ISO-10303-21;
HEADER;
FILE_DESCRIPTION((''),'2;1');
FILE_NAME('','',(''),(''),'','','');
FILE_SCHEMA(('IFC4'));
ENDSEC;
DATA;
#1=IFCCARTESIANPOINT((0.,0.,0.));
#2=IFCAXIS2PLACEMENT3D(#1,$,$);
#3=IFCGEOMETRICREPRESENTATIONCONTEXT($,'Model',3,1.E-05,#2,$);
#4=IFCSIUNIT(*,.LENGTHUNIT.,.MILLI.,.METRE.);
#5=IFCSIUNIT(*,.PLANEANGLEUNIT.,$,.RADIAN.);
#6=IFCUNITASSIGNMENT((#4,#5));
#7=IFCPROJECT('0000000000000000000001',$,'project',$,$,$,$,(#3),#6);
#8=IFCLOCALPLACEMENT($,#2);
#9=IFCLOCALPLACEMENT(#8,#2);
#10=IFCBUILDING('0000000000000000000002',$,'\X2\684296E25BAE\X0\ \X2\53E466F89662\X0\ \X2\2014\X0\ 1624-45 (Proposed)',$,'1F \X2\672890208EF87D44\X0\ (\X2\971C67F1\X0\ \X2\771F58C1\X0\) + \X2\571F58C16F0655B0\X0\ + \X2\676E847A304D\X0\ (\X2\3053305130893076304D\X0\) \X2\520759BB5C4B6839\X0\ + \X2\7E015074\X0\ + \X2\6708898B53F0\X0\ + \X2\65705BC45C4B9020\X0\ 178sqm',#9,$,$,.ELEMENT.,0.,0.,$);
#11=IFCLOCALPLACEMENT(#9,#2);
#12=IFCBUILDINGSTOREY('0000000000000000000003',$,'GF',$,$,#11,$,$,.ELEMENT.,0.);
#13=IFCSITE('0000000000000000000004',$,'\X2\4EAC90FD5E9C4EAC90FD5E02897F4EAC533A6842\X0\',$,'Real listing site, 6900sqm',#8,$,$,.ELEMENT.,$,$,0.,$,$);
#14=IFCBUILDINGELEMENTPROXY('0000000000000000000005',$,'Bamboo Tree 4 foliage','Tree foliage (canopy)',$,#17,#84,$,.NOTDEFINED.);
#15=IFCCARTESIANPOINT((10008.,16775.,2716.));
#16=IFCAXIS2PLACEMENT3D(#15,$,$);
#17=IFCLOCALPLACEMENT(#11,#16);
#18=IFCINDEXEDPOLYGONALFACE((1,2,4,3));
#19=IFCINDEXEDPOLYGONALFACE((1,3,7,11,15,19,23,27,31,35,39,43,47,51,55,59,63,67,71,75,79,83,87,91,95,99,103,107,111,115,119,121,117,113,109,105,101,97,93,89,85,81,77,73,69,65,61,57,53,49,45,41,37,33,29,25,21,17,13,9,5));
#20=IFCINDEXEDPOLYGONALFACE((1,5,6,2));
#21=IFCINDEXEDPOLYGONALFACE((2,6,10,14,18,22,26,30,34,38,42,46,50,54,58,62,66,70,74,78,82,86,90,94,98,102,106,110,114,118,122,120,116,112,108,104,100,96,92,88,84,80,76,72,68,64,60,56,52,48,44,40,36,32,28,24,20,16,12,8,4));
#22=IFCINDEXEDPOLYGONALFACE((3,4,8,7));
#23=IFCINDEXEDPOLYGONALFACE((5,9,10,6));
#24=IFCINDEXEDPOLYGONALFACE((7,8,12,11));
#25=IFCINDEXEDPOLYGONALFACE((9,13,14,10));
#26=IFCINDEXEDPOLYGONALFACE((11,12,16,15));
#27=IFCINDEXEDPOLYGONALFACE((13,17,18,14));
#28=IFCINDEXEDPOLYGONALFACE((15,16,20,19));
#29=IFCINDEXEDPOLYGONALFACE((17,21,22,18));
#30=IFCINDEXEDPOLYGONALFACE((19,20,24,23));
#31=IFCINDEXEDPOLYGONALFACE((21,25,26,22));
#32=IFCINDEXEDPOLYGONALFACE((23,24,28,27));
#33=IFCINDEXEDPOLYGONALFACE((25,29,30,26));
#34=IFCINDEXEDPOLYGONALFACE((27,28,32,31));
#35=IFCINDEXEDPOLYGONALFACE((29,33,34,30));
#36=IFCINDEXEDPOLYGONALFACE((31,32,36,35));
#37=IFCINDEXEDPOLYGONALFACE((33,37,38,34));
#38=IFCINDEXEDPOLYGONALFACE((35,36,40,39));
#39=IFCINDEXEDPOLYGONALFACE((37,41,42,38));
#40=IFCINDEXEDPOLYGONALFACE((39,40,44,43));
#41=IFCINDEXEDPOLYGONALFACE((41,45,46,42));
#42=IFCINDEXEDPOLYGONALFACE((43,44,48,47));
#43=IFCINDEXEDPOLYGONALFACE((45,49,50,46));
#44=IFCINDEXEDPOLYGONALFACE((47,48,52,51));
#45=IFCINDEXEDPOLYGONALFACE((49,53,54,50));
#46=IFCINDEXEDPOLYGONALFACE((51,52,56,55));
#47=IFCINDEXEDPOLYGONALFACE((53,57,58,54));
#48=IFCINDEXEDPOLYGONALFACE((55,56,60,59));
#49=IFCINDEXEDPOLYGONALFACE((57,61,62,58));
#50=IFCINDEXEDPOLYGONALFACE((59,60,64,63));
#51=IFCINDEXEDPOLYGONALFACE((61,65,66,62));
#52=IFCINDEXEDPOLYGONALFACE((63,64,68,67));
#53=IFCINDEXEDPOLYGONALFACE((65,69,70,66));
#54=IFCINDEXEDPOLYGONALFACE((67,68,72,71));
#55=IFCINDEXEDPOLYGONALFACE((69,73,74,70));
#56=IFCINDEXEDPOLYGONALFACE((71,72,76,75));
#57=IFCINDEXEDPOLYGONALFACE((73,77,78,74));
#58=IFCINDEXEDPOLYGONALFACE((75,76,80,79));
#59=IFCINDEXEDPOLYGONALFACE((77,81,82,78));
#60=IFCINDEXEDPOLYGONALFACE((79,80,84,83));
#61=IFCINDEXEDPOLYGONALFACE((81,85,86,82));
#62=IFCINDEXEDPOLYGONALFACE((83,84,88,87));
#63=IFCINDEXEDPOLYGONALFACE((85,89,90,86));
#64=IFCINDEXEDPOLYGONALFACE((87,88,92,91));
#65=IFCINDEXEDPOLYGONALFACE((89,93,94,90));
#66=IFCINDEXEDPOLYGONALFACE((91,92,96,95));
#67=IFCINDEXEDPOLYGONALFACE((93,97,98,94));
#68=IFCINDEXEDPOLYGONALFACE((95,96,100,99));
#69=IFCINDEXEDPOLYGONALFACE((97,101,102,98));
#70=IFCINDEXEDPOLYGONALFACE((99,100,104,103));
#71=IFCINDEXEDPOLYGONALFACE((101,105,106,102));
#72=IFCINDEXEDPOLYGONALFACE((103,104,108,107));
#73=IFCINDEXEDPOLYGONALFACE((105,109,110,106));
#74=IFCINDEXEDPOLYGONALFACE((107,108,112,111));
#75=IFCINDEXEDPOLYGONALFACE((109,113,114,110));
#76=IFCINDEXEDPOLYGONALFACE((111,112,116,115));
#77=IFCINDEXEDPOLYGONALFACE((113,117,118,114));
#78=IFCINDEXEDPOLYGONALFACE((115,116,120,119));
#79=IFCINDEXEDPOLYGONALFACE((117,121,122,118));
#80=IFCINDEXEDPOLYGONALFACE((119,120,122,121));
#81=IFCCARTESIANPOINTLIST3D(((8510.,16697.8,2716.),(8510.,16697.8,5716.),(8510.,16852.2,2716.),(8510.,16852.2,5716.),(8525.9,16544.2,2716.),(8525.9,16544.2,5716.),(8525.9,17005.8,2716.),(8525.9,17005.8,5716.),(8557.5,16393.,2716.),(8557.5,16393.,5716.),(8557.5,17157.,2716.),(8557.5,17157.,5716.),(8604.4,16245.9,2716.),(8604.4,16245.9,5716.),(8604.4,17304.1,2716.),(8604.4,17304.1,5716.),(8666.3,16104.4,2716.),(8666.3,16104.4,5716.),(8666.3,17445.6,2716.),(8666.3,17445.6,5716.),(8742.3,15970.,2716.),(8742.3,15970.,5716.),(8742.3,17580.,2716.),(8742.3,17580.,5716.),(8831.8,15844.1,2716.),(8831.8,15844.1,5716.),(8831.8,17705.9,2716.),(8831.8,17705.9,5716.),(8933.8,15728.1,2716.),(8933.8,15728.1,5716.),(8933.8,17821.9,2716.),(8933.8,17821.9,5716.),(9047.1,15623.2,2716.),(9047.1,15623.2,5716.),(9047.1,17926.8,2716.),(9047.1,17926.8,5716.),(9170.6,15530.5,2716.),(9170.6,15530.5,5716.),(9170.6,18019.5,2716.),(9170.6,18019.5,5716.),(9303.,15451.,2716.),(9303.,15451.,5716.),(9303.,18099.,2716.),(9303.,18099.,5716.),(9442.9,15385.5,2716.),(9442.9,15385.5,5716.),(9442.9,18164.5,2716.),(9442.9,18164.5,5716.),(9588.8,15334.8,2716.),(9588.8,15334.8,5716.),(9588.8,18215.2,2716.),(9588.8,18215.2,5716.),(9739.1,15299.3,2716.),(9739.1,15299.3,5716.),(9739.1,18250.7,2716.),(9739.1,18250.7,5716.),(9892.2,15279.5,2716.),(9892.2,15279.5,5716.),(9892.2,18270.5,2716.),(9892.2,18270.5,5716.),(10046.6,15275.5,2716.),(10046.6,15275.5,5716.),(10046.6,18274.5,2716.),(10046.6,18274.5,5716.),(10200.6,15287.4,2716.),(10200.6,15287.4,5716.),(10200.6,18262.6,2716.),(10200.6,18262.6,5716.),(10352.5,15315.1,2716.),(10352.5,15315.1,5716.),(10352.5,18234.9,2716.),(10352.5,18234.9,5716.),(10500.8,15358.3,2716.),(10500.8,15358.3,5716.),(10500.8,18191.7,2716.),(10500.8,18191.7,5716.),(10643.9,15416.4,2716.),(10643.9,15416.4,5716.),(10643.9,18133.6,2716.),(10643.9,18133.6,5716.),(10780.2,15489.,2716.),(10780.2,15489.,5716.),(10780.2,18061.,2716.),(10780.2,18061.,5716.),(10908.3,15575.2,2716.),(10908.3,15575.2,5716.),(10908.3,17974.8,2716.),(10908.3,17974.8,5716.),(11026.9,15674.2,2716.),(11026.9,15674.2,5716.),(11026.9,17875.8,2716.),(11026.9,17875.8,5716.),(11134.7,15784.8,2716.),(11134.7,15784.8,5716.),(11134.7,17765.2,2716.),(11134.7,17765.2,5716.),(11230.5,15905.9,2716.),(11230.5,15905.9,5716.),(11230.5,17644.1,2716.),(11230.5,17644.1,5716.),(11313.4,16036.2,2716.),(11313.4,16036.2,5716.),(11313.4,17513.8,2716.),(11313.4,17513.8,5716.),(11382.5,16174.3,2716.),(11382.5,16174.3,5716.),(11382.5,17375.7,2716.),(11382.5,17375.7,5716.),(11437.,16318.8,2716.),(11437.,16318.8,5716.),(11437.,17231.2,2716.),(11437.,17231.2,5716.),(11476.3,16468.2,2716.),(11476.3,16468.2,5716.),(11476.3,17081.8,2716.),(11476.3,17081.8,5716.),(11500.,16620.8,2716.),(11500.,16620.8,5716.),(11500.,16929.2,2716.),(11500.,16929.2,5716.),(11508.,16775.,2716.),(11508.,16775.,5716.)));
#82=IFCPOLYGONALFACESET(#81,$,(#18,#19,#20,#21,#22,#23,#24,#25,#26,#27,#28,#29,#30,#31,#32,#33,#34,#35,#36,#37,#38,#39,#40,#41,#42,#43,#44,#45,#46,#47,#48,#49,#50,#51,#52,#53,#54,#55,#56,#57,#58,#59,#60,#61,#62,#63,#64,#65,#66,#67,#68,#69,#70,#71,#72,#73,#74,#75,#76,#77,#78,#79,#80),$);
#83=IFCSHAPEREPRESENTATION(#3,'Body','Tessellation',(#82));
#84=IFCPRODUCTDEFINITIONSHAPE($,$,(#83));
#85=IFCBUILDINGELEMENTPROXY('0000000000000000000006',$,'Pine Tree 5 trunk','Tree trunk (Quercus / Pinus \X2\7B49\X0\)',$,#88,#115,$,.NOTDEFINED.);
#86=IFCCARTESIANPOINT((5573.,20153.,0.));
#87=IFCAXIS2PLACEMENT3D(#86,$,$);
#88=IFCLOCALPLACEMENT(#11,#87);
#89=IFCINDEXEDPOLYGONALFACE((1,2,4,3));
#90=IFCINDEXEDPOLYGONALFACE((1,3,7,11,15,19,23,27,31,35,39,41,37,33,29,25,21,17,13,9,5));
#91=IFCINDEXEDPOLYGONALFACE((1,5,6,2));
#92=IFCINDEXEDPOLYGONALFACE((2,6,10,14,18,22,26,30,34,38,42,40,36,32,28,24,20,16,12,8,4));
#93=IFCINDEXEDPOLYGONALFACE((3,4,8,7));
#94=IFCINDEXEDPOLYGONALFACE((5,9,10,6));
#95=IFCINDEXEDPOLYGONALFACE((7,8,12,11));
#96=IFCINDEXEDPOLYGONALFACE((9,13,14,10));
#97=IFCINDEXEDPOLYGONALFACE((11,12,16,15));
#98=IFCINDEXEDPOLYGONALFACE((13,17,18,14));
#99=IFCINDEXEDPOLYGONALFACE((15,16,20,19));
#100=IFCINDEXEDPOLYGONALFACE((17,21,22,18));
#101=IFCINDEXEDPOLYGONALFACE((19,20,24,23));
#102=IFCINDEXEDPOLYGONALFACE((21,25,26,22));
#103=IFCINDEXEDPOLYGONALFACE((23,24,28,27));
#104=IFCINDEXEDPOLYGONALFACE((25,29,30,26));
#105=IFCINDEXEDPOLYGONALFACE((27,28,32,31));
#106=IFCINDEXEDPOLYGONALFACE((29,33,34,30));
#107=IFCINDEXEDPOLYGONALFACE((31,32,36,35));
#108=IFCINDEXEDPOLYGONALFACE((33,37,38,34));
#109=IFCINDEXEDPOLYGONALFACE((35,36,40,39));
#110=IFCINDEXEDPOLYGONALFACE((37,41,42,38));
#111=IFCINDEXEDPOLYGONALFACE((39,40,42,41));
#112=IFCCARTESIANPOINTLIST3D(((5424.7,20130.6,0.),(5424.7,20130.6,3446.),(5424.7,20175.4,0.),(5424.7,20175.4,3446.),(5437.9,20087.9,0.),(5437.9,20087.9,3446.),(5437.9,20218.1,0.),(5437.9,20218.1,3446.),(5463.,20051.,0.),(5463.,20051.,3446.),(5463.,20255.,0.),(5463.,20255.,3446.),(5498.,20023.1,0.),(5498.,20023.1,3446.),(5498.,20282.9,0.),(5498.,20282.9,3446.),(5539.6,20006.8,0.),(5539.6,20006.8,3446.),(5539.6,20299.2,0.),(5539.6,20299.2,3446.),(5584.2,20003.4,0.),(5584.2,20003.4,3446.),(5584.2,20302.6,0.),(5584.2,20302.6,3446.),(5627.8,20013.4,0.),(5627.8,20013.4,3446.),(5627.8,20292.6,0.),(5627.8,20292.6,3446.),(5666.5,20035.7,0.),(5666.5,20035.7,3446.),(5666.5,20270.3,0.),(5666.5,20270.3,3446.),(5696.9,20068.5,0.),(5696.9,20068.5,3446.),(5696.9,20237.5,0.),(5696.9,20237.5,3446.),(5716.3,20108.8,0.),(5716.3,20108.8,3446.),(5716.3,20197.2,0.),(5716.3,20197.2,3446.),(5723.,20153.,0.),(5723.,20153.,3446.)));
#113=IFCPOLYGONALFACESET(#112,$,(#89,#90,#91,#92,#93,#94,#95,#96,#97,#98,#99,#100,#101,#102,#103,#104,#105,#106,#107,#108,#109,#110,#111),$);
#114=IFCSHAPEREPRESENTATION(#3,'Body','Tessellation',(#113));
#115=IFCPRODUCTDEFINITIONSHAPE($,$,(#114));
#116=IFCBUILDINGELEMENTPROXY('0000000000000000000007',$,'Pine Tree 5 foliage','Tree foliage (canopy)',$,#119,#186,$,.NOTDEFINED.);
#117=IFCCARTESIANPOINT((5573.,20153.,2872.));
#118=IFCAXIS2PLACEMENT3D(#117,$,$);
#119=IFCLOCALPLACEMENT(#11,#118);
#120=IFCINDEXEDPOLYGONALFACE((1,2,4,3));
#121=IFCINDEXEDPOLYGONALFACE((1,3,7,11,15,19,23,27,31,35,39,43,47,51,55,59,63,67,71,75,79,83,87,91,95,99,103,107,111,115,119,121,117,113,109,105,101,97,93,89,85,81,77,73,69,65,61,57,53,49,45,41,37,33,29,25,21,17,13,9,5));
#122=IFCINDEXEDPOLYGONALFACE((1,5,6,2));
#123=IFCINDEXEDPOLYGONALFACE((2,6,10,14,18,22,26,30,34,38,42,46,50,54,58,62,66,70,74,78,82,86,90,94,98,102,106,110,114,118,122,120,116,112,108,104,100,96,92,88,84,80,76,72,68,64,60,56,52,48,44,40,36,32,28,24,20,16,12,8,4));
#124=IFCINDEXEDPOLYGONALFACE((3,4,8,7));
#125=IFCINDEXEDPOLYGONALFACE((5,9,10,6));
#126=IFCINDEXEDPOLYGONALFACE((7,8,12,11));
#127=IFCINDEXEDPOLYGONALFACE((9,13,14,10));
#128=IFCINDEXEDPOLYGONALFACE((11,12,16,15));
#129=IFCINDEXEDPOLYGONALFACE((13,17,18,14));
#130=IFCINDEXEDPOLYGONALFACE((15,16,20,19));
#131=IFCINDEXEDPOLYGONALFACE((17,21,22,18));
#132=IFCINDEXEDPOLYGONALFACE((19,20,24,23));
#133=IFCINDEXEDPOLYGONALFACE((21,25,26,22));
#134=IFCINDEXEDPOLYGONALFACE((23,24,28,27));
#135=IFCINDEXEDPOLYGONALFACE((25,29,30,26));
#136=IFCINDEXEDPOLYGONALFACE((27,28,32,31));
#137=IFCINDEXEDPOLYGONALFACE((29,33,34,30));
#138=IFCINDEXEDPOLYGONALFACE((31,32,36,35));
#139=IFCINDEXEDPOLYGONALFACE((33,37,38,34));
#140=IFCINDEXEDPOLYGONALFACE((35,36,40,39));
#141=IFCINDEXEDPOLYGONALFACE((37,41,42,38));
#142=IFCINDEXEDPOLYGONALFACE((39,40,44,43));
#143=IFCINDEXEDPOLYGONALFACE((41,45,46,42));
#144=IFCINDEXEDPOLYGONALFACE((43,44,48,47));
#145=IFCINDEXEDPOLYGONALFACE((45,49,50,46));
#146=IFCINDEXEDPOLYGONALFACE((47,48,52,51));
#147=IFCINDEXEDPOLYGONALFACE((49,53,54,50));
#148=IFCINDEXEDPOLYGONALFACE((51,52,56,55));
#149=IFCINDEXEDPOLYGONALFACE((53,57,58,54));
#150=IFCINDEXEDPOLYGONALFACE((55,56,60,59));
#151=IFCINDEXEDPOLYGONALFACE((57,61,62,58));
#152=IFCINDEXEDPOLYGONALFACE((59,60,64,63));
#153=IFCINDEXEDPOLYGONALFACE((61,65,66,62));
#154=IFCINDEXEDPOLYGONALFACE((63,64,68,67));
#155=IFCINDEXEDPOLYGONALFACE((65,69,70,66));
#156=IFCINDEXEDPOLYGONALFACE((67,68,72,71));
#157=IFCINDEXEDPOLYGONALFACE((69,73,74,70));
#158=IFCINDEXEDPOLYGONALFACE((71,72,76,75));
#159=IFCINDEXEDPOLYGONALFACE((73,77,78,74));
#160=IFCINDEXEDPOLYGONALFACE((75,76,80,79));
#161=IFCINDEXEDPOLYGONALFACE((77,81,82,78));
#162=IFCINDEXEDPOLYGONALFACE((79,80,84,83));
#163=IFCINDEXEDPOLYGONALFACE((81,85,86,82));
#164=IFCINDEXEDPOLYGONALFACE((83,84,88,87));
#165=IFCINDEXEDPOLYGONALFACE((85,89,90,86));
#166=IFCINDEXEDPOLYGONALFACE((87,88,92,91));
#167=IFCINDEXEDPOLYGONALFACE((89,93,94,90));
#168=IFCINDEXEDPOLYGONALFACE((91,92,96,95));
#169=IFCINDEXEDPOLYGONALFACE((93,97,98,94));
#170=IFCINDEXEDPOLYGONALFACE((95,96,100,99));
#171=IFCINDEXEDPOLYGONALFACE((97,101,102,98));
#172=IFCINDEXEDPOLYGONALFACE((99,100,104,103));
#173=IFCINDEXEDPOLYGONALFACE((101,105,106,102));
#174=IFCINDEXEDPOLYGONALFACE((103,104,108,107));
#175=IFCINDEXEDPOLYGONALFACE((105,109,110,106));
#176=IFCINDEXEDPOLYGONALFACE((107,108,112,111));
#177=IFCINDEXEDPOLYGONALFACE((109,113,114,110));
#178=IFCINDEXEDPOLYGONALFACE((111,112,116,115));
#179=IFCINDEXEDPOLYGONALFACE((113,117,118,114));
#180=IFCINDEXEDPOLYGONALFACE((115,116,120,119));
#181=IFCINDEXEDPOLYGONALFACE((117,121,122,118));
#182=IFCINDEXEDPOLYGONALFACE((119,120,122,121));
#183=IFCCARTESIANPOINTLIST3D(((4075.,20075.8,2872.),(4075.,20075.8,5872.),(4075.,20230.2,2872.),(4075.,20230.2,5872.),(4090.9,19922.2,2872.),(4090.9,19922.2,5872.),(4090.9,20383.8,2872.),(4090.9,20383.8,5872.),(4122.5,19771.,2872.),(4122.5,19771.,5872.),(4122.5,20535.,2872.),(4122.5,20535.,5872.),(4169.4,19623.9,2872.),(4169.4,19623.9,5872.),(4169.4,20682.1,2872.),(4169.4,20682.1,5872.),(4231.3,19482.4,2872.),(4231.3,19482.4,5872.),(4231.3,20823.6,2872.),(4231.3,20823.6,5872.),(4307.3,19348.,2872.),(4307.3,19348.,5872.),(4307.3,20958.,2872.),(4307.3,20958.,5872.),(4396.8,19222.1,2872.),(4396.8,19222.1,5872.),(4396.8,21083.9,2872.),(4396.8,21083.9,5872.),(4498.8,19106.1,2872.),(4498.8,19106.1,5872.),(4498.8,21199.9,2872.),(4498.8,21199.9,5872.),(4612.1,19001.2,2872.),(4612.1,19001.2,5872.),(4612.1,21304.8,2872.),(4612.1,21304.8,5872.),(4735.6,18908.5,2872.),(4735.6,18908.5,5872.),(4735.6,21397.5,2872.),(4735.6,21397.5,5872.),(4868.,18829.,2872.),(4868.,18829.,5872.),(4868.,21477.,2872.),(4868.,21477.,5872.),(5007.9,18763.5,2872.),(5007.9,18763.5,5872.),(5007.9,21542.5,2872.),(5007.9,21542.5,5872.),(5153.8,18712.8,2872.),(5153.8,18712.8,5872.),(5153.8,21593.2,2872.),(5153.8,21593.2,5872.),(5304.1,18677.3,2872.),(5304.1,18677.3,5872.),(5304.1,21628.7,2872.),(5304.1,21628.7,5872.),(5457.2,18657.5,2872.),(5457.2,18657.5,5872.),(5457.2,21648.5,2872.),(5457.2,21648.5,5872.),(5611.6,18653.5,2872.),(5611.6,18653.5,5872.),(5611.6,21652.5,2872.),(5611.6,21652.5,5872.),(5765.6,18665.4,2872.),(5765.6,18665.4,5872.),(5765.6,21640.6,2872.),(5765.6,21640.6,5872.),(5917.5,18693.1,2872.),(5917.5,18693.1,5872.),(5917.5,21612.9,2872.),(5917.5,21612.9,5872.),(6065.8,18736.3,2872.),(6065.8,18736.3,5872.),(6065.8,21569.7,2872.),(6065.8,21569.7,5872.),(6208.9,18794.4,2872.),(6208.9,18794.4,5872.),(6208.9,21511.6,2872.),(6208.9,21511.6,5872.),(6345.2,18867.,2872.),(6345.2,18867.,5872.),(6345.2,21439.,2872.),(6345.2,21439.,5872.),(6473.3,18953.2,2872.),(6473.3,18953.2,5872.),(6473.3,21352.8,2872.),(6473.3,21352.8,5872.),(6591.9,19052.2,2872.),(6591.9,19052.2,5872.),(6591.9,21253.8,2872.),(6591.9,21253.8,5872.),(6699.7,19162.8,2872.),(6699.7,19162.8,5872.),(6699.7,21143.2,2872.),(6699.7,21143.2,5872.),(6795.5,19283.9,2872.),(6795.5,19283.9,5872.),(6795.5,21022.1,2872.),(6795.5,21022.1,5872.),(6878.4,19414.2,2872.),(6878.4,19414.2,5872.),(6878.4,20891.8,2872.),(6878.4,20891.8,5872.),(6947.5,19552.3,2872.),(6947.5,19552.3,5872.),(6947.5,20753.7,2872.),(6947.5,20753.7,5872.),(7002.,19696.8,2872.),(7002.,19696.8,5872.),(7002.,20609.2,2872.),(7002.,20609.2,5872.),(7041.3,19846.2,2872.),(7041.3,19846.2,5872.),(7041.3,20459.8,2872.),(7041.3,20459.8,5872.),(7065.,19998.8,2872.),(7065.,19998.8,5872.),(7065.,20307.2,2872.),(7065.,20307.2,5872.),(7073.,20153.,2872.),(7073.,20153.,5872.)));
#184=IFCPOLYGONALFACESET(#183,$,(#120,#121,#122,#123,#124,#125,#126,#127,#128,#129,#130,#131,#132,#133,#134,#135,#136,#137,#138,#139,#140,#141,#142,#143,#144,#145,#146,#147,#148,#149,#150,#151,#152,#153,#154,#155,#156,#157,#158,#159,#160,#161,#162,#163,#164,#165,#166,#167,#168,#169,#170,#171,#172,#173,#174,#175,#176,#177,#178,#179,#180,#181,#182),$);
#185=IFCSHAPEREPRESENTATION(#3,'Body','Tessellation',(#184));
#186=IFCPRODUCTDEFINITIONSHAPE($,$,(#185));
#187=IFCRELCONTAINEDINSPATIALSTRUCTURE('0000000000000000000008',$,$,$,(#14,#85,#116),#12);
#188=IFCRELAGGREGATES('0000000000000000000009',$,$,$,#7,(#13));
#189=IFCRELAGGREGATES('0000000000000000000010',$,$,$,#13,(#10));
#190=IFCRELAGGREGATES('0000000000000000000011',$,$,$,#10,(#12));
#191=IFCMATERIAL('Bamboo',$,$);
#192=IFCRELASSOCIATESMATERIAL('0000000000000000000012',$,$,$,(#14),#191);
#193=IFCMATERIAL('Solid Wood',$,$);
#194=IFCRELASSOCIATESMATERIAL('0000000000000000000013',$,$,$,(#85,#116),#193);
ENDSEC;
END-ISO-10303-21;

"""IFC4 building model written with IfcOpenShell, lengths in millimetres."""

from ifc_helpers import new_model, si_unit, frame, origin, origin_2d, place, context, project, spatial, circle, extrude, material, element, save


model = new_model("IFC4")

# Units and contexts
model_context = context("Model", 3, precision=1e-05, world=origin())
ifc_project = project(units=[si_unit("LENGTHUNIT", "METRE", prefix="MILLI"), si_unit("PLANEANGLEUNIT", "RADIAN")], contexts=[model_context])

# Site, building, storey
site_placement = place(None, origin())
site = spatial("IfcSite", under=ifc_project, at=site_placement, Name="京都府京都市西京区桂", ObjectType="Real listing site, 6900sqm", CompositionType="ELEMENT", RefElevation=0.0)
building_placement = place(site_placement, origin())
building = spatial("IfcBuilding", under=site, at=building_placement, Name="桂離宮 古書院 — 1624-45 (Proposed)", ObjectType="1F 木造軸組 (霜柱 真壁) + 土壁漆喰 + 杮葺き (こけらぶき) 切妻屋根 + 縁側 + 月見台 + 数寄屋造 178sqm", CompositionType="ELEMENT", ElevationOfRefHeight=0.0, ElevationOfTerrain=0.0)
storey_placement = place(building_placement, origin())
storey = spatial("IfcBuildingStorey", under=building, at=storey_placement, Name="GF", CompositionType="ELEMENT", Elevation=0.0)

# Shared definitions
ifc_material_1 = material(Name="Solid Wood")

# Building element proxies
ifc_material_2 = material(Name="Bamboo")
proxy_1_placement = place(storey_placement, frame((10008.0, 16775.0, 2716.0)))
element("IfcBuildingElementProxy", 1, at=proxy_1_placement, inside=storey, material=ifc_material_2, Name="Bamboo Tree 4 foliage", Description="Tree foliage (canopy)", PredefinedType="NOTDEFINED", context=model_context, shape_type="SweptSolid", body=[
    extrude(circle(Radius=1500.0, at=origin_2d()), frame((10008.0, 16775.0, 2716.0)), (0.0, 0.0, 1.0), 3000.0),
])
proxy_2_placement = place(storey_placement, frame((5573.0, 20153.0, 0.0)))
element("IfcBuildingElementProxy", 2, at=proxy_2_placement, inside=storey, material=ifc_material_1, Name="Pine Tree 5 trunk", Description="Tree trunk (Quercus / Pinus 等)", PredefinedType="NOTDEFINED", context=model_context, shape_type="SweptSolid", body=[
    extrude(circle(Radius=150.0, at=origin_2d()), frame((5573.0, 20153.0, 0.0)), (0.0, 0.0, 1.0), 3446.0),
])
proxy_3_placement = place(storey_placement, frame((5573.0, 20153.0, 2872.0)))
element("IfcBuildingElementProxy", 3, at=proxy_3_placement, inside=storey, material=ifc_material_1, Name="Pine Tree 5 foliage", Description="Tree foliage (canopy)", PredefinedType="NOTDEFINED", context=model_context, shape_type="SweptSolid", body=[
    extrude(circle(Radius=1500.0, at=origin_2d()), frame((5573.0, 20153.0, 2872.0)), (0.0, 0.0, 1.0), 3000.0),
])

save(model, "model.ifc")
